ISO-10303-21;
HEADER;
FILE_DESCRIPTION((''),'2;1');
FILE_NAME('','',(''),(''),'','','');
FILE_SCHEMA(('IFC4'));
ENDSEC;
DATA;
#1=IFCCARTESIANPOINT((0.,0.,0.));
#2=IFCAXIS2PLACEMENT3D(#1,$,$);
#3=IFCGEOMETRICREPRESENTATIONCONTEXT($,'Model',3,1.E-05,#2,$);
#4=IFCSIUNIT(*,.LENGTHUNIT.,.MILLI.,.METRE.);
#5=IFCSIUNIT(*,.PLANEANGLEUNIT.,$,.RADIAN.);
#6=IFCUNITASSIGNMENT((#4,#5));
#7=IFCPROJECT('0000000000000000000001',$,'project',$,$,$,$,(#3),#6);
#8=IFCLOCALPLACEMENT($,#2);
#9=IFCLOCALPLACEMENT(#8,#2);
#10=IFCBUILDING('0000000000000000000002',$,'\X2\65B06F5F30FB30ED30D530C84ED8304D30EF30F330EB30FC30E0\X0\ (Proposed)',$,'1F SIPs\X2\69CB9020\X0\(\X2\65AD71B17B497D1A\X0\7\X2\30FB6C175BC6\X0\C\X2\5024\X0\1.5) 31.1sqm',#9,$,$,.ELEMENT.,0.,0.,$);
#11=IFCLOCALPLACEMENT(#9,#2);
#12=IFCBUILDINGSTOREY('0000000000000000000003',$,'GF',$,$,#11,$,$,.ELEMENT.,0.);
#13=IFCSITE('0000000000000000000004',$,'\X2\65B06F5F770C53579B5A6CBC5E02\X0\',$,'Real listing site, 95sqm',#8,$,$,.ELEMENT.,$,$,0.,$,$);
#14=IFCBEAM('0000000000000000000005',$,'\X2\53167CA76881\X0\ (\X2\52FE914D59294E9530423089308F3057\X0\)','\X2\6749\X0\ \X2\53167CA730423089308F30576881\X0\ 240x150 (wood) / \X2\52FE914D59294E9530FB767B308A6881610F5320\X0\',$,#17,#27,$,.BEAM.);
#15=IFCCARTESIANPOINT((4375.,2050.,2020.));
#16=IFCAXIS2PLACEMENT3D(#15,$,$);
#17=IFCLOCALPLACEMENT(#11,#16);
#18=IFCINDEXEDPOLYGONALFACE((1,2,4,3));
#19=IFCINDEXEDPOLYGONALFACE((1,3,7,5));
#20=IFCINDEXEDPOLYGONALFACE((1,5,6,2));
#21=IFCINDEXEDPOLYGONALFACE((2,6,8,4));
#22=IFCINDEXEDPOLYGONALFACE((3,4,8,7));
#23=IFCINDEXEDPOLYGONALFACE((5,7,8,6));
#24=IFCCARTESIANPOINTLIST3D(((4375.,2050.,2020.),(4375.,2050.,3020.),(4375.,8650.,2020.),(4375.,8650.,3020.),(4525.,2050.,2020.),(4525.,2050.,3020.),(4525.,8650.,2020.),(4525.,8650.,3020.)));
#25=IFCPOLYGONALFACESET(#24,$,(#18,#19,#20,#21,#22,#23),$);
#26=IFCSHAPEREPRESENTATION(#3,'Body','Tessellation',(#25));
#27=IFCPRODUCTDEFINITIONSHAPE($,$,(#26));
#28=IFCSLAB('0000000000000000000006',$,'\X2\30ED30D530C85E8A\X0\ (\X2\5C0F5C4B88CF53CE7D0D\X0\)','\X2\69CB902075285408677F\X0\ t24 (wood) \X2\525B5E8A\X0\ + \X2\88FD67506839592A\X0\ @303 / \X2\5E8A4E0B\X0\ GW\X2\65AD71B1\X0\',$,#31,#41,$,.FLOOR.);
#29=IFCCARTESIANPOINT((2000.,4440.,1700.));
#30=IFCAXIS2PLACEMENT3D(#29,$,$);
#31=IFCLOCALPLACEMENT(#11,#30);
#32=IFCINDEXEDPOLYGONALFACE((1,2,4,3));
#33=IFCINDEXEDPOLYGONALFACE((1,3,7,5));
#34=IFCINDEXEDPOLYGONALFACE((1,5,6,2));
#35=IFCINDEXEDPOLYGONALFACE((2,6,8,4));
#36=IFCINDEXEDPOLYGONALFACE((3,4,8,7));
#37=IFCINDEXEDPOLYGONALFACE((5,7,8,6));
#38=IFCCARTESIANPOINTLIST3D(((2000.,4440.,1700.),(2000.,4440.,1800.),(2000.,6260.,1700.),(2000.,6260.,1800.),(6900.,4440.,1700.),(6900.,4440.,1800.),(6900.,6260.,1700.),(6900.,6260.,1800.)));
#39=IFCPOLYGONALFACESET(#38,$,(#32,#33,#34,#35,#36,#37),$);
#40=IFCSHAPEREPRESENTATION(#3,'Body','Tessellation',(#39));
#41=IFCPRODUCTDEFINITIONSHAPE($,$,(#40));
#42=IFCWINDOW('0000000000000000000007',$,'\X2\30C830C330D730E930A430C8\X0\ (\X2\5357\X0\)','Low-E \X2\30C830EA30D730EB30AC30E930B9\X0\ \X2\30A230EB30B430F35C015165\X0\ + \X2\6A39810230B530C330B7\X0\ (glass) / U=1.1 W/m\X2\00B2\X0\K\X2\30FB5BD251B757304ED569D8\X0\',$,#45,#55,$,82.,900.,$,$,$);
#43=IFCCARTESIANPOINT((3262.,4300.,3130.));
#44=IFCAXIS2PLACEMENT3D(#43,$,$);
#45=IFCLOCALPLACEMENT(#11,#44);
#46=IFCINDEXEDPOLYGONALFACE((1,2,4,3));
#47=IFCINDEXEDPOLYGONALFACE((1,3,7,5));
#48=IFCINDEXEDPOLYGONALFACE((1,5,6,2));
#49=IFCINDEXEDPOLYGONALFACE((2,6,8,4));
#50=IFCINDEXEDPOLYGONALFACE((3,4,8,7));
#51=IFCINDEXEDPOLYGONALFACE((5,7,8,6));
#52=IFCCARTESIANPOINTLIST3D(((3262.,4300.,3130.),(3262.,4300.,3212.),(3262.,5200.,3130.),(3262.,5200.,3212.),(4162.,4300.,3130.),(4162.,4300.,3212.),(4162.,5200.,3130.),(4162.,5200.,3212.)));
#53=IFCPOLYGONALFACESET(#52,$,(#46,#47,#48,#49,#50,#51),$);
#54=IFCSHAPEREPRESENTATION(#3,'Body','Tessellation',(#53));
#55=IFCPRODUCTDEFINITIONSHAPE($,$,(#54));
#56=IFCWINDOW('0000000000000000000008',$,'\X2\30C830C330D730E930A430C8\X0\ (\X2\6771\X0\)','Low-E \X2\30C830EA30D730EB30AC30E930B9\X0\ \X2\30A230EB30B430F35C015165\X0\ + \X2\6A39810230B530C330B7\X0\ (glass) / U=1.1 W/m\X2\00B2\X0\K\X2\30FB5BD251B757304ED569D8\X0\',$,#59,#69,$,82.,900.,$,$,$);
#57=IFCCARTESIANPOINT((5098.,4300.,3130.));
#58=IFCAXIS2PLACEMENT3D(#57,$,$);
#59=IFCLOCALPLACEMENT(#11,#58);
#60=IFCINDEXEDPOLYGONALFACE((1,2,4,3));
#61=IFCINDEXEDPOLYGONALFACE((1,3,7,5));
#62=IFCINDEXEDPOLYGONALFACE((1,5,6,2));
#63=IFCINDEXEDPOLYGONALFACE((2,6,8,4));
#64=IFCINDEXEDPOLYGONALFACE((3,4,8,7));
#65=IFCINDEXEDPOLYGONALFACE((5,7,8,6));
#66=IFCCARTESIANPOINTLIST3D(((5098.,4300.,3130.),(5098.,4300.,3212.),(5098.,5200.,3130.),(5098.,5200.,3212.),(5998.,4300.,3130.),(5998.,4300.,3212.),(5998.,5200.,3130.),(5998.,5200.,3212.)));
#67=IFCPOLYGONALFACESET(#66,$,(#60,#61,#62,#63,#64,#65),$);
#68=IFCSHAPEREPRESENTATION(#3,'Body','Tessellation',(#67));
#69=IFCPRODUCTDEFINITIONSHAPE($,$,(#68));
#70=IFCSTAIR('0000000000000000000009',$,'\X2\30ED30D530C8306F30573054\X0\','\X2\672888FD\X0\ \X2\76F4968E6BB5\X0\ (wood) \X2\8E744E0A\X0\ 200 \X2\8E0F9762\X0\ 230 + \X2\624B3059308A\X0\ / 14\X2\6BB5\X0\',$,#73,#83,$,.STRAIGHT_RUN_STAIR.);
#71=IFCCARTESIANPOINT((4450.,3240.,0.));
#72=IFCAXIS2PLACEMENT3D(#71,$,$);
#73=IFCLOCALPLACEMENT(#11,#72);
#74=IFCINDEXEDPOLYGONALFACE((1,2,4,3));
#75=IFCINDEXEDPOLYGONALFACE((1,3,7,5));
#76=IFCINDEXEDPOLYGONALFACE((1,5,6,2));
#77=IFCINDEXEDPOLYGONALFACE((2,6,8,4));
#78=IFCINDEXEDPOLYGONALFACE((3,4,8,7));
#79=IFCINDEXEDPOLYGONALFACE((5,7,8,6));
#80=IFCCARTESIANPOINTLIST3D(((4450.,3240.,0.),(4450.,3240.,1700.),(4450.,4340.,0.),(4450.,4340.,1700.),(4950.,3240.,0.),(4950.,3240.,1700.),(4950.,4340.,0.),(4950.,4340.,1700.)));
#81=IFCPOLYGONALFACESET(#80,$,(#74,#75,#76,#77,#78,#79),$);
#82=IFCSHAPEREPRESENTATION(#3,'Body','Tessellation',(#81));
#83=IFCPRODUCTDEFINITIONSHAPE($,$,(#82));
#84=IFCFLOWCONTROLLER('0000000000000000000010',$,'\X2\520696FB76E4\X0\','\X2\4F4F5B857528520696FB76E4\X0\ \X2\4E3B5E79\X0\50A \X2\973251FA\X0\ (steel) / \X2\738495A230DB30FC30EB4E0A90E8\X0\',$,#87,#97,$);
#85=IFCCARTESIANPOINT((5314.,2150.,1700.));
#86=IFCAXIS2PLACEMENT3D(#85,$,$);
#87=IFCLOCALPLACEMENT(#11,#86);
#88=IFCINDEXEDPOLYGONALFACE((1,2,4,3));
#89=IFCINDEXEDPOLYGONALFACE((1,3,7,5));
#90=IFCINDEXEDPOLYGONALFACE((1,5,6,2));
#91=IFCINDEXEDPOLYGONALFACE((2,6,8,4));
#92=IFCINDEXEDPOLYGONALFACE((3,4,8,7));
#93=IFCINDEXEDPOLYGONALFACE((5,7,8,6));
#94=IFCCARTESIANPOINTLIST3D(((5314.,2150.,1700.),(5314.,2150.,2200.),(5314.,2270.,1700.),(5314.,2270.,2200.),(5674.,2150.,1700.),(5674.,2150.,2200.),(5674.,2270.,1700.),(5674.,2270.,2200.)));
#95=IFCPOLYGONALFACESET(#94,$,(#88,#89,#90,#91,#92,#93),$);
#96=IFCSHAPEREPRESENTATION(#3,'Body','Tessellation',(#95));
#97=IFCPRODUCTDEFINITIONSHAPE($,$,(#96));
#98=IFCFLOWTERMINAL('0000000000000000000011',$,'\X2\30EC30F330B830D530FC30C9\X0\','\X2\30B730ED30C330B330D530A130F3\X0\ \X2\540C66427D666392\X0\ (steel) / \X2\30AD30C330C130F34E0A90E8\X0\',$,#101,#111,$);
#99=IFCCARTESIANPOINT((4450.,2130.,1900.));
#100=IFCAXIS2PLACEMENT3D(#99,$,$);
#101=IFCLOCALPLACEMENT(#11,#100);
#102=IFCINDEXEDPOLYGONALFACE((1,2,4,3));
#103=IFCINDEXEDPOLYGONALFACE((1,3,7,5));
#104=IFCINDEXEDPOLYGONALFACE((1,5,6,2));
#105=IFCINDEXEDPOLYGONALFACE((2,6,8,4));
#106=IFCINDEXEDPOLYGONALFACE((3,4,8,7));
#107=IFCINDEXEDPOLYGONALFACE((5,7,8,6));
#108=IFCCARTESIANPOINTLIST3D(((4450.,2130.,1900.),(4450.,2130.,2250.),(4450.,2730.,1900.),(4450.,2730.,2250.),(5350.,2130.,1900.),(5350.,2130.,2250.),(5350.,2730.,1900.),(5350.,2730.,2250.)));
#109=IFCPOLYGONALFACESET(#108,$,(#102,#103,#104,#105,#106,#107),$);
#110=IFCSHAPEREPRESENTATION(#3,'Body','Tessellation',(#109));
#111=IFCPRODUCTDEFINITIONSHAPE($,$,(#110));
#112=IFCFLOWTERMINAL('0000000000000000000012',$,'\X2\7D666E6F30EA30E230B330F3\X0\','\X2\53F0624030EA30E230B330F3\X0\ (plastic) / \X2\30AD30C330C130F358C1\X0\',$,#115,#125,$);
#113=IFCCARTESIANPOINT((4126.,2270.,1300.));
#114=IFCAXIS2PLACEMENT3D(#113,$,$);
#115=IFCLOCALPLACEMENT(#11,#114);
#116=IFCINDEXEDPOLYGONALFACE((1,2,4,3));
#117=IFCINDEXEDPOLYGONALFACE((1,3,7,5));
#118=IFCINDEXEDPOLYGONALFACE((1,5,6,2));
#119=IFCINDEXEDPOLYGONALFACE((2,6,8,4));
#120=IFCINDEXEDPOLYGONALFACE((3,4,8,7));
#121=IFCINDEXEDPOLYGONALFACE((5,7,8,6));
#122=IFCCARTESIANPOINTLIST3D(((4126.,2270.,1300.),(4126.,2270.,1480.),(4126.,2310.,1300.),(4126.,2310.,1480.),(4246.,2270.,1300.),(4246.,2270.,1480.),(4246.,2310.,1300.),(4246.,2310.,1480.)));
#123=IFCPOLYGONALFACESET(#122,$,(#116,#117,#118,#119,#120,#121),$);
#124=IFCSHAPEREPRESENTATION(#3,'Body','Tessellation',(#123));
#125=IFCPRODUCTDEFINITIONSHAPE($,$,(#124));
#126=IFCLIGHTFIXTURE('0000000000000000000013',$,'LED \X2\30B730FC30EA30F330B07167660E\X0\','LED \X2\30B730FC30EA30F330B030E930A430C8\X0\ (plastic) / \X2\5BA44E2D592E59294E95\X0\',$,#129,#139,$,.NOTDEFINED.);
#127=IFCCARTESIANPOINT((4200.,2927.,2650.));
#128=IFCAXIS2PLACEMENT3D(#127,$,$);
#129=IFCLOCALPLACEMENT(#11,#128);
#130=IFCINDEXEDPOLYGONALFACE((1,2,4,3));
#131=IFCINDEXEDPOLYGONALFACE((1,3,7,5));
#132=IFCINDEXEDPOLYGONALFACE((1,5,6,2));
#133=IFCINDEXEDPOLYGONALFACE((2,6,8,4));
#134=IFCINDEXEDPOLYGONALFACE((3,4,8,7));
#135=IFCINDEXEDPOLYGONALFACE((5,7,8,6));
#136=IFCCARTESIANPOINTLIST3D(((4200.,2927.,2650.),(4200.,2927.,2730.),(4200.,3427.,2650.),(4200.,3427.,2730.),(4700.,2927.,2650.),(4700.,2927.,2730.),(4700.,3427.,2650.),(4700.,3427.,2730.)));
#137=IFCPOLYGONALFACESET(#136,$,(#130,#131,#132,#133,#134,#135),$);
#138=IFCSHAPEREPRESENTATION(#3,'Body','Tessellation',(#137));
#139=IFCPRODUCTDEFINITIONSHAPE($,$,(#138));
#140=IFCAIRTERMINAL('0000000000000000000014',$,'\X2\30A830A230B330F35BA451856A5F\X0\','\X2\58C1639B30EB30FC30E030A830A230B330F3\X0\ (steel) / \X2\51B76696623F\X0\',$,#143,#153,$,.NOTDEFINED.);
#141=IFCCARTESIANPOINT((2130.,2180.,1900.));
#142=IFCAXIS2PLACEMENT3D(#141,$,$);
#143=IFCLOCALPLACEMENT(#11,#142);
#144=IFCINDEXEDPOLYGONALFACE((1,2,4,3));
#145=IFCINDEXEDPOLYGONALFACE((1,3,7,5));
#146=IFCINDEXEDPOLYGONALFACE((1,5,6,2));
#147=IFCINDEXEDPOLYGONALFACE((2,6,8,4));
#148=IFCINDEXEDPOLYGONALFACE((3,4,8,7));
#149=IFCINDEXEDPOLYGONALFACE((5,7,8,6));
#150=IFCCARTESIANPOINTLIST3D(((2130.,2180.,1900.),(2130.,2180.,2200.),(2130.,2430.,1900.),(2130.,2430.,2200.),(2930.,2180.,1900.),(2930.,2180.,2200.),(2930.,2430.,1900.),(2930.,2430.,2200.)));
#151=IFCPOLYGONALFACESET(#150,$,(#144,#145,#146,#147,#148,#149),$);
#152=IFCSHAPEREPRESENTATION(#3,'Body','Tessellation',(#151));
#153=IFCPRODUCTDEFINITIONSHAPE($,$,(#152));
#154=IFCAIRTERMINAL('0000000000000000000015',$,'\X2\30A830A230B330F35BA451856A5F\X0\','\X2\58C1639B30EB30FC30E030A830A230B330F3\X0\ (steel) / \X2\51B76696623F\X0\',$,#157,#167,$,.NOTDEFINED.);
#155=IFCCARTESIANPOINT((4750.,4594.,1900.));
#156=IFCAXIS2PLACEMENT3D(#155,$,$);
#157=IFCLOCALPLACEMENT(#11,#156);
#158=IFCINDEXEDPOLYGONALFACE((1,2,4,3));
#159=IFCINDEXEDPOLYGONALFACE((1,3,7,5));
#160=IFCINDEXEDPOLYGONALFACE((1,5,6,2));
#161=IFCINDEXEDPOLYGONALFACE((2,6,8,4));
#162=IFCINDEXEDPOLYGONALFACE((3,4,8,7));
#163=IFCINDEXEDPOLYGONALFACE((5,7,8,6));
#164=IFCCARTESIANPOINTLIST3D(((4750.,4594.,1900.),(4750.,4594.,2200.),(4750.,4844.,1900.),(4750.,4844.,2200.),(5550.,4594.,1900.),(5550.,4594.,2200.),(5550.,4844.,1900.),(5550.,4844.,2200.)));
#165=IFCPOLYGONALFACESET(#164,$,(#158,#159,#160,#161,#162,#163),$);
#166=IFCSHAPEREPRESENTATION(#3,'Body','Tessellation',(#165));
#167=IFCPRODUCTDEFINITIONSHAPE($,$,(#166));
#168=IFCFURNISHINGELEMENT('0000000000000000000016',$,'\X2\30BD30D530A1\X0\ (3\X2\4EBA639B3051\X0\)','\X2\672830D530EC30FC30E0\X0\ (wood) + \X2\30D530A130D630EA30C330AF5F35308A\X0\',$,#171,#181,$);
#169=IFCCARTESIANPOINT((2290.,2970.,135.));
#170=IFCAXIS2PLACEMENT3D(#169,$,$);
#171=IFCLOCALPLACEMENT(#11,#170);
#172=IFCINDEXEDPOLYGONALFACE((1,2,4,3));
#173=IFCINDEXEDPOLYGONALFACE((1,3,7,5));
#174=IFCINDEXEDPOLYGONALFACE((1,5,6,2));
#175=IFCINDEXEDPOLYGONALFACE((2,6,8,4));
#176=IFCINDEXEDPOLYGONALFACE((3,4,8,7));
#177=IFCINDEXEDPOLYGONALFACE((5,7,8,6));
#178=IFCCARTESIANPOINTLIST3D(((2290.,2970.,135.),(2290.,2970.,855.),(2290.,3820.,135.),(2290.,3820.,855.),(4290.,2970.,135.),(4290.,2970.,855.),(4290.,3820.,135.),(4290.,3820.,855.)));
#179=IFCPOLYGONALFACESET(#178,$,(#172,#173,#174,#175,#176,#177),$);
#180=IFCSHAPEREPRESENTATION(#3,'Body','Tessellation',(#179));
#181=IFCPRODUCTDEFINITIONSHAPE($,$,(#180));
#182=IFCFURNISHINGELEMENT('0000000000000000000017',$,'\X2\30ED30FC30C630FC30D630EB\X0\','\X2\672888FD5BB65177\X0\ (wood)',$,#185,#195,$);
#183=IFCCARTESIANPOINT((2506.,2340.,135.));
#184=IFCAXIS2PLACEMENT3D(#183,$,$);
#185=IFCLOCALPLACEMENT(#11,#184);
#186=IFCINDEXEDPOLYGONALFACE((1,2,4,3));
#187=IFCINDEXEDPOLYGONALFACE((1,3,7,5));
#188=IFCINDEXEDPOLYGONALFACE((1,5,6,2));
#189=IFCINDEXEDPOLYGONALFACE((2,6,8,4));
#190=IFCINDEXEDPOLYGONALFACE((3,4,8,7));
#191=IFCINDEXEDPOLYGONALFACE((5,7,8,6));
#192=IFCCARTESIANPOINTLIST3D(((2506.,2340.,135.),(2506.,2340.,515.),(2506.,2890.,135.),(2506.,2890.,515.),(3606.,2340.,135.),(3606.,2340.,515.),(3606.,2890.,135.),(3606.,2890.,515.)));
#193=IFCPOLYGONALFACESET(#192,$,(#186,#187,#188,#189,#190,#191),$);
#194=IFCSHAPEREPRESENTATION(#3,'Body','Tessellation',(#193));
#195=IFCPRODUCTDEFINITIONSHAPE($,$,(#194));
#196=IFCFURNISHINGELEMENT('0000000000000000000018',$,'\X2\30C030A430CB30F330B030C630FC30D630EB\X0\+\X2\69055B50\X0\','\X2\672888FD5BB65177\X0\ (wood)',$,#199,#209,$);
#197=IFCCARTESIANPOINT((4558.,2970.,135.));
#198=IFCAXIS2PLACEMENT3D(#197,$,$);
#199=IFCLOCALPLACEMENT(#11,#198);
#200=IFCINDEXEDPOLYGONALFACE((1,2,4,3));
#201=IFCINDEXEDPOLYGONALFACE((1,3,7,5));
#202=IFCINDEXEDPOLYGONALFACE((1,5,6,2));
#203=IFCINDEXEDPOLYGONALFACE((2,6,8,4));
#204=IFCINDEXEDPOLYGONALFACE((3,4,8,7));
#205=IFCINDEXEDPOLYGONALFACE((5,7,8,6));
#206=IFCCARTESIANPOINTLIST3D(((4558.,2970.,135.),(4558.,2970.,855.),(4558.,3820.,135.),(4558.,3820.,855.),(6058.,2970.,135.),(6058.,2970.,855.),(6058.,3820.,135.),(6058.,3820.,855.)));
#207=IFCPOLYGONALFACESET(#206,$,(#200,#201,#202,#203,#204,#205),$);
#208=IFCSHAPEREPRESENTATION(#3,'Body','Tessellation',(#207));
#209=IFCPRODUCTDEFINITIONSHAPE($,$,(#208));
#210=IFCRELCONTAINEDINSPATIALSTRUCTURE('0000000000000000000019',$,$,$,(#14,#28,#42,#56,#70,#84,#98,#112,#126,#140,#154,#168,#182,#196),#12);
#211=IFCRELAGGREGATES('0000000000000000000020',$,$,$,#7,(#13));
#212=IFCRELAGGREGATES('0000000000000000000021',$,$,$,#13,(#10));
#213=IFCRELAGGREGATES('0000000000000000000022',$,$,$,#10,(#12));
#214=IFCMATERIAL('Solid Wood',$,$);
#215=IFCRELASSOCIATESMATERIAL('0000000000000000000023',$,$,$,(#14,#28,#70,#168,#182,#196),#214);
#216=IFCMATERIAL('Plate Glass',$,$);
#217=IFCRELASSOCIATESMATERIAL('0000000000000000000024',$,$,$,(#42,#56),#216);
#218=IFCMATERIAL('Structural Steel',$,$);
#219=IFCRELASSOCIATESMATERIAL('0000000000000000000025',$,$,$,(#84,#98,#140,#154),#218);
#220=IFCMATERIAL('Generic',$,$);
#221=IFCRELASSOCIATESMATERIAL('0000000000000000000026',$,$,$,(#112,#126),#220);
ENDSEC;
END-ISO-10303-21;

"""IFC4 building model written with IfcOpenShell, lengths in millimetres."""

from ifc_helpers import new_model, si_unit, frame, frame_2d, origin, place, context, project, spatial, rectangle, extrude, material, element, save


model = new_model("IFC4")

# Units and contexts
model_context = context("Model", 3, precision=1e-05, world=origin())
ifc_project = project(units=[si_unit("LENGTHUNIT", "METRE", prefix="MILLI"), si_unit("PLANEANGLEUNIT", "RADIAN")], contexts=[model_context])

# Site, building, storey
site_placement = place(None, origin())
site = spatial("IfcSite", under=ifc_project, at=site_placement, Name="新潟県南魚沼市", ObjectType="Real listing site, 95sqm", CompositionType="ELEMENT", RefElevation=0.0)
building_placement = place(site_placement, origin())
building = spatial("IfcBuilding", under=site, at=building_placement, Name="新潟・ロフト付きワンルーム (Proposed)", ObjectType="1F SIPs構造(断熱等級7・気密C値1.5) 31.1sqm", CompositionType="ELEMENT", ElevationOfRefHeight=0.0, ElevationOfTerrain=0.0)
storey_placement = place(building_placement, origin())
storey = spatial("IfcBuildingStorey", under=building, at=storey_placement, Name="GF", CompositionType="ELEMENT", Elevation=0.0)

# Shared definitions
ifc_material_1 = material(Name="Solid Wood")

# Beam
beam_placement = place(storey_placement, frame((4375.0, 2050.0, 2020.0)))
element("IfcBeam", 1, at=beam_placement, inside=storey, material=ifc_material_1, Name="化粧梁 (勾配天井あらわし)", Description="杉 化粧あらわし梁 240x150 (wood) / 勾配天井・登り梁意匠", PredefinedType="BEAM", context=model_context, shape_type="SweptSolid", body=[
    extrude(rectangle(XDim=150.0, YDim=6600.0, at=frame_2d((75.0, 3300.0))), frame((4375.0, 2050.0, 2020.0)), (0.0, 0.0, 1.0), 1000.0),
])

# Slab
slab_placement = place(storey_placement, frame((2000.0, 4440.0, 1700.0)))
element("IfcSlab", 2, at=slab_placement, inside=storey, material=ifc_material_1, Name="ロフト床 (小屋裏収納)", Description="構造用合板 t24 (wood) 剛床 + 製材根太 @303 / 床下 GW断熱", PredefinedType="FLOOR", context=model_context, shape_type="SweptSolid", body=[
    extrude(rectangle(XDim=4900.0, YDim=1820.0, at=frame_2d((2450.0, 910.0))), frame((2000.0, 4440.0, 1700.0)), (0.0, 0.0, 1.0), 100.0),
])

# Windows
ifc_material_2 = material(Name="Plate Glass")
window_1_placement = place(storey_placement, frame((3262.0, 4300.0, 3130.0)))
element("IfcWindow", 3, at=window_1_placement, inside=storey, material=ifc_material_2, Name="トップライト (南)", Description="Low-E トリプルガラス アルゴン封入 + 樹脂サッシ (glass) / U=1.1 W/m²K・寒冷地仕様", OverallHeight=82.0, OverallWidth=900.0, context=model_context, shape_type="SweptSolid", body=[
    extrude(rectangle(XDim=900.0, YDim=900.0, at=frame_2d((450.0, 450.0))), frame((3262.0, 4300.0, 3130.0)), (0.0, 0.0, 1.0), 82.0),
])
window_2_placement = place(storey_placement, frame((5098.0, 4300.0, 3130.0)))
element("IfcWindow", 4, at=window_2_placement, inside=storey, material=ifc_material_2, Name="トップライト (東)", Description="Low-E トリプルガラス アルゴン封入 + 樹脂サッシ (glass) / U=1.1 W/m²K・寒冷地仕様", OverallHeight=82.0, OverallWidth=900.0, context=model_context, shape_type="SweptSolid", body=[
    extrude(rectangle(XDim=900.0, YDim=900.0, at=frame_2d((450.0, 450.0))), frame((5098.0, 4300.0, 3130.0)), (0.0, 0.0, 1.0), 82.0),
])

# Stair
stair_placement = place(storey_placement, frame((4450.0, 3240.0, 0.0)))
element("IfcStair", 5, at=stair_placement, inside=storey, material=ifc_material_1, Name="ロフトはしご", Description="木製 直階段 (wood) 蹴上 200 踏面 230 + 手すり / 14段", PredefinedType="STRAIGHT_RUN_STAIR", context=model_context, shape_type="SweptSolid", body=[
    extrude(rectangle(XDim=500.0, YDim=1100.0, at=frame_2d((250.0, 550.0))), frame((4450.0, 3240.0, 0.0)), (0.0, 0.0, 1.0), 1700.0),
])

# Flow controller
ifc_material_3 = material(Name="Structural Steel")
flow_controller_placement = place(storey_placement, frame((5314.0, 2150.0, 1700.0)))
element("IfcFlowController", 6, at=flow_controller_placement, inside=storey, material=ifc_material_3, Name="分電盤", Description="住宅用分電盤 主幹50A 露出 (steel) / 玄関ホール上部", context=model_context, shape_type="SweptSolid", body=[
    extrude(rectangle(XDim=360.0, YDim=120.0, at=frame_2d((180.0, 60.0))), frame((5314.0, 2150.0, 1700.0)), (0.0, 0.0, 1.0), 500.0),
])

# Flow terminals
flow_terminal_1_placement = place(storey_placement, frame((4450.0, 2130.0, 1900.0)))
element("IfcFlowTerminal", 7, at=flow_terminal_1_placement, inside=storey, material=ifc_material_3, Name="レンジフード", Description="シロッコファン 同時給排 (steel) / キッチン上部", context=model_context, shape_type="SweptSolid", body=[
    extrude(rectangle(XDim=900.0, YDim=600.0, at=frame_2d((450.0, 300.0))), frame((4450.0, 2130.0, 1900.0)), (0.0, 0.0, 1.0), 350.0),
])
ifc_material_4 = material(Name="Generic")
flow_terminal_2_placement = place(storey_placement, frame((4126.0, 2270.0, 1300.0)))
element("IfcFlowTerminal", 8, at=flow_terminal_2_placement, inside=storey, material=ifc_material_4, Name="給湯リモコン", Description="台所リモコン (plastic) / キッチン壁", context=model_context, shape_type="SweptSolid", body=[
    extrude(rectangle(XDim=120.0, YDim=40.0, at=frame_2d((60.0, 20.0))), frame((4126.0, 2270.0, 1300.0)), (0.0, 0.0, 1.0), 180.0),
])

# Light fixture
light_fixture_placement = place(storey_placement, frame((4200.0, 2927.0, 2650.0)))
element("IfcLightFixture", 9, at=light_fixture_placement, inside=storey, material=ifc_material_4, Name="LED シーリング照明", Description="LED シーリングライト (plastic) / 室中央天井", PredefinedType="NOTDEFINED", context=model_context, shape_type="SweptSolid", body=[
    extrude(rectangle(XDim=500.0, YDim=500.0, at=frame_2d((250.0, 250.0))), frame((4200.0, 2927.0, 2650.0)), (0.0, 0.0, 1.0), 80.0),
])

# Air terminals
air_terminal_1_placement = place(storey_placement, frame((2130.0, 2180.0, 1900.0)))
element("IfcAirTerminal", 10, at=air_terminal_1_placement, inside=storey, material=ifc_material_3, Name="エアコン室内機", Description="壁掛ルームエアコン (steel) / 冷暖房", PredefinedType="NOTDEFINED", context=model_context, shape_type="SweptSolid", body=[
    extrude(rectangle(XDim=800.0, YDim=250.0, at=frame_2d((400.0, 125.0))), frame((2130.0, 2180.0, 1900.0)), (0.0, 0.0, 1.0), 300.0),
])
air_terminal_2_placement = place(storey_placement, frame((4750.0, 4594.0, 1900.0)))
element("IfcAirTerminal", 11, at=air_terminal_2_placement, inside=storey, material=ifc_material_3, Name="エアコン室内機", Description="壁掛ルームエアコン (steel) / 冷暖房", PredefinedType="NOTDEFINED", context=model_context, shape_type="SweptSolid", body=[
    extrude(rectangle(XDim=800.0, YDim=250.0, at=frame_2d((400.0, 125.0))), frame((4750.0, 4594.0, 1900.0)), (0.0, 0.0, 1.0), 300.0),
])

# Furnishing elements
furnishing_1_placement = place(storey_placement, frame((2290.0, 2970.0, 135.0)))
element("IfcFurnishingElement", 12, at=furnishing_1_placement, inside=storey, material=ifc_material_1, Name="ソファ (3人掛け)", Description="木フレーム (wood) + ファブリック張り", context=model_context, shape_type="SweptSolid", body=[
    extrude(rectangle(XDim=2000.0, YDim=850.0, at=frame_2d((1000.0, 425.0))), frame((2290.0, 2970.0, 135.0)), (0.0, 0.0, 1.0), 720.0),
])
furnishing_2_placement = place(storey_placement, frame((2506.0, 2340.0, 135.0)))
element("IfcFurnishingElement", 13, at=furnishing_2_placement, inside=storey, material=ifc_material_1, Name="ローテーブル", Description="木製家具 (wood)", context=model_context, shape_type="SweptSolid", body=[
    extrude(rectangle(XDim=1100.0, YDim=550.0, at=frame_2d((550.0, 275.0))), frame((2506.0, 2340.0, 135.0)), (0.0, 0.0, 1.0), 380.0),
])
furnishing_3_placement = place(storey_placement, frame((4558.0, 2970.0, 135.0)))
element("IfcFurnishingElement", 14, at=furnishing_3_placement, inside=storey, material=ifc_material_1, Name="ダイニングテーブル+椅子", Description="木製家具 (wood)", context=model_context, shape_type="SweptSolid", body=[
    extrude(rectangle(XDim=1500.0, YDim=850.0, at=frame_2d((750.0, 425.0))), frame((4558.0, 2970.0, 135.0)), (0.0, 0.0, 1.0), 720.0),
])

save(model, "model.ifc")
